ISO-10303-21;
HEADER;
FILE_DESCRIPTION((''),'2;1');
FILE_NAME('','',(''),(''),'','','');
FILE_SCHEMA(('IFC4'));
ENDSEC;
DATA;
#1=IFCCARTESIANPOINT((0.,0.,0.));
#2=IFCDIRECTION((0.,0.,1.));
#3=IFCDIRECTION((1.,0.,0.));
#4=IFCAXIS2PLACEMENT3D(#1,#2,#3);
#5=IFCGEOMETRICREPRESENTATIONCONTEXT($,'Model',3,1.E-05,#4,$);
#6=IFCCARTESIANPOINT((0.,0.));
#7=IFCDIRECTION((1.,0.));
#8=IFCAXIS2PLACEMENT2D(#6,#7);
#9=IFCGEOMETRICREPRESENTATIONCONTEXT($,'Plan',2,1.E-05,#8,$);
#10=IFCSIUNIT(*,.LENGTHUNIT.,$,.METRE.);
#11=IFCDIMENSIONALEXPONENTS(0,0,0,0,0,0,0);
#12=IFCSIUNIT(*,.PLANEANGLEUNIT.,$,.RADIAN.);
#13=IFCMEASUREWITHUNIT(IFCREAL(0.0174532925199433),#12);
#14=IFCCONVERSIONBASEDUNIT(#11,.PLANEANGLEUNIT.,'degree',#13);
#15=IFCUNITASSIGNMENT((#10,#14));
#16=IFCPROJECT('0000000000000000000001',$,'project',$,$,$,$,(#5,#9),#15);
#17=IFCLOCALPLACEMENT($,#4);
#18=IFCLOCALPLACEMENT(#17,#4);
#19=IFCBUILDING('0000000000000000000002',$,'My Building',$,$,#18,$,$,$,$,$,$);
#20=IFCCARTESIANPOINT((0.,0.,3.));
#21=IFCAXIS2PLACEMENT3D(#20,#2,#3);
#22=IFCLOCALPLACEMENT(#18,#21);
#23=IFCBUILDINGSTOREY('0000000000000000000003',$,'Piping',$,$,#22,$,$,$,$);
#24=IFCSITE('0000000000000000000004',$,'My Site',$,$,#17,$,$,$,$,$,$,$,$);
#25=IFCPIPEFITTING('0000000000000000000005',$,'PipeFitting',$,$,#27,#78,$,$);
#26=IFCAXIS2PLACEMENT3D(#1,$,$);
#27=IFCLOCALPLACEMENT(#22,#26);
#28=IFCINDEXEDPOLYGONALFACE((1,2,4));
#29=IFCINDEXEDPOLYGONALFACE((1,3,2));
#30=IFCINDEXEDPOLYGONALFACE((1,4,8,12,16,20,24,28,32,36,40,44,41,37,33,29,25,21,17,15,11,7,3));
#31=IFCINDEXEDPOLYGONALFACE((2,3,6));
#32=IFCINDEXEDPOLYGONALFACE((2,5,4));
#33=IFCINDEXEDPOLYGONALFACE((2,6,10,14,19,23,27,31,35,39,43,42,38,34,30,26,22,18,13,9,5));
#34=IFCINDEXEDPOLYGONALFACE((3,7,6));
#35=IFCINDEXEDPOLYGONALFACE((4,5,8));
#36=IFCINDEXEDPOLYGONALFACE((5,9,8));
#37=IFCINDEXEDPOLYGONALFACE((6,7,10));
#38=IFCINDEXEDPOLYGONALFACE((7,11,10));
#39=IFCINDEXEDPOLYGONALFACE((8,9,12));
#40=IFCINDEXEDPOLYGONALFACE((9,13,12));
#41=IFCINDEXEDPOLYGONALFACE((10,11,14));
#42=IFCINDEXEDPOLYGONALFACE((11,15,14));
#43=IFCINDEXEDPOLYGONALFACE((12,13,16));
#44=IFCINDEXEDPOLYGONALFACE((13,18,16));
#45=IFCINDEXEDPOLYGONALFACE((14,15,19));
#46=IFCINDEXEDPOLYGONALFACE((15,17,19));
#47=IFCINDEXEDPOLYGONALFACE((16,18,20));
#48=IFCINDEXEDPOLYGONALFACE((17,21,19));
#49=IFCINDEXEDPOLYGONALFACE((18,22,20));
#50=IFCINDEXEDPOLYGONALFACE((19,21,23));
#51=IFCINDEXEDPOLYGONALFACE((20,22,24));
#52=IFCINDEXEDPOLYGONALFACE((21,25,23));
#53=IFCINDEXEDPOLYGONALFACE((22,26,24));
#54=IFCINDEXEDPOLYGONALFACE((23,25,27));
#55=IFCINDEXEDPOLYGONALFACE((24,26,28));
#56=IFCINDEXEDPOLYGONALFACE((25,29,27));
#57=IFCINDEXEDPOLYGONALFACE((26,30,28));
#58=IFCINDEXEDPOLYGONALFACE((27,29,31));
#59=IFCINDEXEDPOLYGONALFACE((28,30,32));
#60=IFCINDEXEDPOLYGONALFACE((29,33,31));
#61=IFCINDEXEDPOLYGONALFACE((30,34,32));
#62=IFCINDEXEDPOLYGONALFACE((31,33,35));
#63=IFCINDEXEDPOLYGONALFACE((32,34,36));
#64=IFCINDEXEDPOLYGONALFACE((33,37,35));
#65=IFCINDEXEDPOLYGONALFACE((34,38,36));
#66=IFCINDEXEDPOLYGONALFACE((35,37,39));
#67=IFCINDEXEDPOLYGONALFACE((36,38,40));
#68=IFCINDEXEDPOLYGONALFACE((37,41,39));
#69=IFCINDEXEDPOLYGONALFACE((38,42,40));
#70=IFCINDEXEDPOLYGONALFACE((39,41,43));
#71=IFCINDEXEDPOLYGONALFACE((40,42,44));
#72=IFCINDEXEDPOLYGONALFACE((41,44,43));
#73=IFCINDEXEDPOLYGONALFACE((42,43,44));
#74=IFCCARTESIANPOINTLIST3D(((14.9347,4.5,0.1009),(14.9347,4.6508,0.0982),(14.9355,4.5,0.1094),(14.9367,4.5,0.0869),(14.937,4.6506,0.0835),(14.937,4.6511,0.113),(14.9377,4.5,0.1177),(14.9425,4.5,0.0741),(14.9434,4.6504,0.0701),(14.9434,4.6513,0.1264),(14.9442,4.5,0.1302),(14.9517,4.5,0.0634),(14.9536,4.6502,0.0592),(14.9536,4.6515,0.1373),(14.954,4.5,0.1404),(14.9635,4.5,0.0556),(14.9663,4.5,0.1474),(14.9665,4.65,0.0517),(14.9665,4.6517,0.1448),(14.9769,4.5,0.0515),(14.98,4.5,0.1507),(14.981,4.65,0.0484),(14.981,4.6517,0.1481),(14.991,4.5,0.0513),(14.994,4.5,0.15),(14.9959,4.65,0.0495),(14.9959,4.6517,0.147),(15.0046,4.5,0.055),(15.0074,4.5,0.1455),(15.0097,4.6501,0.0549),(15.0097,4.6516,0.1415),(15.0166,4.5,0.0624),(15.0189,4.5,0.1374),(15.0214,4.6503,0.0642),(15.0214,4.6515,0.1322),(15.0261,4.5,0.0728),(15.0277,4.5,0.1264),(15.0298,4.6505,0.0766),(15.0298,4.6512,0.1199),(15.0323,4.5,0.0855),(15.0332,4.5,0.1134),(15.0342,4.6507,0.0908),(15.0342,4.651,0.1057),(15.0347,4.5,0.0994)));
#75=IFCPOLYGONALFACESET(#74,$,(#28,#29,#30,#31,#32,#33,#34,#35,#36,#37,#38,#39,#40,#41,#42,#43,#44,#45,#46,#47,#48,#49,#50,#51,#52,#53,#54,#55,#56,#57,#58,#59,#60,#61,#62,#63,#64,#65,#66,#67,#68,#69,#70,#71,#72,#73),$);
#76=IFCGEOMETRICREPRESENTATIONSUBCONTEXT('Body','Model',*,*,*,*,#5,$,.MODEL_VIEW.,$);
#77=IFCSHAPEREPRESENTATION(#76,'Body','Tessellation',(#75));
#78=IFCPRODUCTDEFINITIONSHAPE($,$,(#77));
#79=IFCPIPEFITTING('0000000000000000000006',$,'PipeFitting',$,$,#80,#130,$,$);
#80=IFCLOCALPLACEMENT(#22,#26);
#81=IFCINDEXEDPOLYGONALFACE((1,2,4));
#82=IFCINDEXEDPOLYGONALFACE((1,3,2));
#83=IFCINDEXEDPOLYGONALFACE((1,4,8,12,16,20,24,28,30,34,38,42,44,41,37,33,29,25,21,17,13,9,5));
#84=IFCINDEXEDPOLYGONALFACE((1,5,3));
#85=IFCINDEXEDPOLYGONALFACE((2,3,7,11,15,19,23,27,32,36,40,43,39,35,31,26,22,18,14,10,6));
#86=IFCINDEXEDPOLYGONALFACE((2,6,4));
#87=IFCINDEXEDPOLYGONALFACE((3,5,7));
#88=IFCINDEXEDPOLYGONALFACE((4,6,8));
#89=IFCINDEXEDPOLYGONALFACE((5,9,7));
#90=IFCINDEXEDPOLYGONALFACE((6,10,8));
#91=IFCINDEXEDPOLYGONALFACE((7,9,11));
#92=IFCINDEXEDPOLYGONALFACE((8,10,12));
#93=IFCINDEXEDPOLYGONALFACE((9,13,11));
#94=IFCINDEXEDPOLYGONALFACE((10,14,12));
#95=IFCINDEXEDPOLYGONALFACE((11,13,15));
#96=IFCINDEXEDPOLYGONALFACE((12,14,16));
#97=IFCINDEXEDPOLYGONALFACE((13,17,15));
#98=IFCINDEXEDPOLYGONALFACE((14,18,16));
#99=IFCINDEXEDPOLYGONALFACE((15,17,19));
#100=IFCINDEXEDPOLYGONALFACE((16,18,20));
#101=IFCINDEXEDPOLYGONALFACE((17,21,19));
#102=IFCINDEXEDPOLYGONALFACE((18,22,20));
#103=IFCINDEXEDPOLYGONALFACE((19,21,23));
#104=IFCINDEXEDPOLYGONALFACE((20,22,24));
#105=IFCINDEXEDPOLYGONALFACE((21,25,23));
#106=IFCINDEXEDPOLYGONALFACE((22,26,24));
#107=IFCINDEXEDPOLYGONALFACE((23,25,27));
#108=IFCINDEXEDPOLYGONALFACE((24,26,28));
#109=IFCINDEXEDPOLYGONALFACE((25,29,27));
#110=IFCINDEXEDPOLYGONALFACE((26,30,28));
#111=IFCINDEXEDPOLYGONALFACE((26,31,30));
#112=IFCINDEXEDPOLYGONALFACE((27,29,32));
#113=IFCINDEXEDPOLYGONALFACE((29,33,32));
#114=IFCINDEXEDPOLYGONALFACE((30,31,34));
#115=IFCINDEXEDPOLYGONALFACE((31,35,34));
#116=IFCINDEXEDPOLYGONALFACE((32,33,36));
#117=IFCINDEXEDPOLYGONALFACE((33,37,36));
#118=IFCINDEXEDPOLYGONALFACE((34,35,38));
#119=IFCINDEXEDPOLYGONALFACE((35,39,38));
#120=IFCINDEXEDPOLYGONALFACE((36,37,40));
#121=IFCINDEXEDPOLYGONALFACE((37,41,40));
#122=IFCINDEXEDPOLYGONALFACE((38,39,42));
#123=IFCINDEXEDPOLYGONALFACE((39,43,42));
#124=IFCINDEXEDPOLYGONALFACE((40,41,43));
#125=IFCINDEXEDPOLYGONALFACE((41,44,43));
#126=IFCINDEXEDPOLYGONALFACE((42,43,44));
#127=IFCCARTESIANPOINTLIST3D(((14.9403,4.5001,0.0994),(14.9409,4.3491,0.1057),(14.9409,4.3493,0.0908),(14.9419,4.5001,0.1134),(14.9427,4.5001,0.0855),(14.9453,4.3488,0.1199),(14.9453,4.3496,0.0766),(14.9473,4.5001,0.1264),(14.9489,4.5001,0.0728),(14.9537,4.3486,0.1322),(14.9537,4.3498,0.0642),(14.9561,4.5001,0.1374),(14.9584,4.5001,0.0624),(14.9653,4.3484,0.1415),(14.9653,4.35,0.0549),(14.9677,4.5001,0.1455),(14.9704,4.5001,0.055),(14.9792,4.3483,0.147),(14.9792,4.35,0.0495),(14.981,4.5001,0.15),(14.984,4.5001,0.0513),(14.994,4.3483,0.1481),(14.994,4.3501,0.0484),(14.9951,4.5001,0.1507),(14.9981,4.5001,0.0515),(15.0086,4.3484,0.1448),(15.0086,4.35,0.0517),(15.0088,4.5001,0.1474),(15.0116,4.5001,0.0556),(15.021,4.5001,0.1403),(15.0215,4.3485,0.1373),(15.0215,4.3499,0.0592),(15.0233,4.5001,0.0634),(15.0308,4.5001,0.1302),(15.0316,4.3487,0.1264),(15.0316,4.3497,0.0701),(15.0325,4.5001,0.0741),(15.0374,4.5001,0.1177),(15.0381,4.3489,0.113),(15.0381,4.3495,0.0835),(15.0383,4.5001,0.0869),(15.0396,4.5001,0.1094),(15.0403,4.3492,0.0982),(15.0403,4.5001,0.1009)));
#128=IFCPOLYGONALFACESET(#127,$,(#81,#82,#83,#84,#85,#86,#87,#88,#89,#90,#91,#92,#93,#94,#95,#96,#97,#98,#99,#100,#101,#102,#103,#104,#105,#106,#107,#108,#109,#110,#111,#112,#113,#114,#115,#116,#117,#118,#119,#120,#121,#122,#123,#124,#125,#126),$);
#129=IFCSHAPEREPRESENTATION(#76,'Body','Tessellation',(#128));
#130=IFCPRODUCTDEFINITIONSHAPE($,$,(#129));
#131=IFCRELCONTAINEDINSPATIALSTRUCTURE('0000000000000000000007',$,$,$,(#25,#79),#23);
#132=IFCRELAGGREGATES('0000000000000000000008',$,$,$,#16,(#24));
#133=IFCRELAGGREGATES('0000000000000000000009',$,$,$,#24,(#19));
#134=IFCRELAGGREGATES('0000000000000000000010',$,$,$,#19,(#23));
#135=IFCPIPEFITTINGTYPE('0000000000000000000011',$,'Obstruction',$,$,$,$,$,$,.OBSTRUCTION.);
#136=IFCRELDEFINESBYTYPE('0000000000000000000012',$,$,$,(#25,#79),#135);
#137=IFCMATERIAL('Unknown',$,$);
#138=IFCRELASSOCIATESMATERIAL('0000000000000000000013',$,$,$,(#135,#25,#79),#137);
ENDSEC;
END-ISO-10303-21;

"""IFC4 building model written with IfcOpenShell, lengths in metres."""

from ifc_helpers import new_model, entity, si_unit, converted_unit, frame, origin_with_axes, origin_2d_with_axis, place, context, subcontext, project, spatial, circle, extrude, clip, halfspace, material, material_profile, profile_set, profile_usage, type_object, element, save


model = new_model("IFC4")

# Units and contexts
model_context = context("Model", 3, precision=1e-05, world=origin_with_axes())
plan_context = context("Plan", 2, precision=1e-05, world=origin_2d_with_axis())
body_context = subcontext(model_context, "Body", "Model", "MODEL_VIEW")
ifc_project = project(units=[si_unit("LENGTHUNIT", "METRE"), converted_unit("PLANEANGLEUNIT", "degree", entity("IfcReal", 0.0174532925199433), si_unit("PLANEANGLEUNIT", "RADIAN"), dimensions=[0, 0, 0, 0, 0, 0, 0])], contexts=[model_context, plan_context])

# Site, building, storey
site_placement = place(None, origin_with_axes())
site = spatial("IfcSite", under=ifc_project, at=site_placement, Name="My Site")
building_placement = place(site_placement, origin_with_axes())
building = spatial("IfcBuilding", under=site, at=building_placement, Name="My Building")
storey_placement = place(building_placement, frame((0.0, 0.0, 3.0), z_axis=(0.0, 0.0, 1.0), x_axis=(1.0, 0.0, 0.0)))
storey = spatial("IfcBuildingStorey", under=building, at=storey_placement, Name="Piping")

# Shared definitions
ifc_material = material(Name="Unknown")

# Pipe fittings
ifc_material_profile_1 = material_profile(ifc_material, circle(Radius=0.05))
ifc_profile_set_1 = profile_set([ifc_material_profile_1])
pipe_fitting_type_1 = type_object("IfcPipeFittingType", Name="Obstruction", PredefinedType="OBSTRUCTION", material=ifc_profile_set_1)
ifc_profile_usage_1 = profile_usage(ifc_profile_set_1, cardinal=5)
pipe_fitting_1_placement = place(storey_placement, frame((14.9849, 2.988, 0.1275), z_axis=(-0.000099, 0.999846, -0.017575), x_axis=(-1.0, -0.000099, 0.0)))
element("IfcPipeFitting", 1, at=pipe_fitting_1_placement, inside=storey, type_object=pipe_fitting_type_1, material=ifc_profile_usage_1, Name="PipeFitting", context=body_context, shape_type="Clipping", body=[
    clip(extrude(circle(Radius=0.05), origin_with_axes(), (0.0, 0.0, 1.0), 1.6631), halfspace(frame((14.9853, 0.0496, 1.5111), z_axis=(-0.000023, -0.017637, -0.999844), x_axis=(-0.999999, 0.001295, 0.0)), False)),
])
ifc_profile_usage_2 = profile_usage(ifc_profile_set_1, cardinal=5)
pipe_fitting_2_placement = place(storey_placement, frame((14.9901, 6.0122, 0.1275), z_axis=(0.000099, -0.999846, -0.017575), x_axis=(1.0, 0.000099, -0.000001)))
element("IfcPipeFitting", 2, at=pipe_fitting_2_placement, inside=storey, type_object=pipe_fitting_type_1, material=ifc_profile_usage_2, Name="PipeFitting", context=body_context, shape_type="Clipping", body=[
    clip(extrude(circle(Radius=0.05), origin_with_axes(), (0.0, 0.0, 1.0), 1.6633), halfspace(frame((-14.9908, 0.0496, 1.5118), z_axis=(-0.000023, -0.017517, -0.999847), x_axis=(-0.999999, 0.001303, 0.0)), False)),
])

save(model, "model.ifc")
